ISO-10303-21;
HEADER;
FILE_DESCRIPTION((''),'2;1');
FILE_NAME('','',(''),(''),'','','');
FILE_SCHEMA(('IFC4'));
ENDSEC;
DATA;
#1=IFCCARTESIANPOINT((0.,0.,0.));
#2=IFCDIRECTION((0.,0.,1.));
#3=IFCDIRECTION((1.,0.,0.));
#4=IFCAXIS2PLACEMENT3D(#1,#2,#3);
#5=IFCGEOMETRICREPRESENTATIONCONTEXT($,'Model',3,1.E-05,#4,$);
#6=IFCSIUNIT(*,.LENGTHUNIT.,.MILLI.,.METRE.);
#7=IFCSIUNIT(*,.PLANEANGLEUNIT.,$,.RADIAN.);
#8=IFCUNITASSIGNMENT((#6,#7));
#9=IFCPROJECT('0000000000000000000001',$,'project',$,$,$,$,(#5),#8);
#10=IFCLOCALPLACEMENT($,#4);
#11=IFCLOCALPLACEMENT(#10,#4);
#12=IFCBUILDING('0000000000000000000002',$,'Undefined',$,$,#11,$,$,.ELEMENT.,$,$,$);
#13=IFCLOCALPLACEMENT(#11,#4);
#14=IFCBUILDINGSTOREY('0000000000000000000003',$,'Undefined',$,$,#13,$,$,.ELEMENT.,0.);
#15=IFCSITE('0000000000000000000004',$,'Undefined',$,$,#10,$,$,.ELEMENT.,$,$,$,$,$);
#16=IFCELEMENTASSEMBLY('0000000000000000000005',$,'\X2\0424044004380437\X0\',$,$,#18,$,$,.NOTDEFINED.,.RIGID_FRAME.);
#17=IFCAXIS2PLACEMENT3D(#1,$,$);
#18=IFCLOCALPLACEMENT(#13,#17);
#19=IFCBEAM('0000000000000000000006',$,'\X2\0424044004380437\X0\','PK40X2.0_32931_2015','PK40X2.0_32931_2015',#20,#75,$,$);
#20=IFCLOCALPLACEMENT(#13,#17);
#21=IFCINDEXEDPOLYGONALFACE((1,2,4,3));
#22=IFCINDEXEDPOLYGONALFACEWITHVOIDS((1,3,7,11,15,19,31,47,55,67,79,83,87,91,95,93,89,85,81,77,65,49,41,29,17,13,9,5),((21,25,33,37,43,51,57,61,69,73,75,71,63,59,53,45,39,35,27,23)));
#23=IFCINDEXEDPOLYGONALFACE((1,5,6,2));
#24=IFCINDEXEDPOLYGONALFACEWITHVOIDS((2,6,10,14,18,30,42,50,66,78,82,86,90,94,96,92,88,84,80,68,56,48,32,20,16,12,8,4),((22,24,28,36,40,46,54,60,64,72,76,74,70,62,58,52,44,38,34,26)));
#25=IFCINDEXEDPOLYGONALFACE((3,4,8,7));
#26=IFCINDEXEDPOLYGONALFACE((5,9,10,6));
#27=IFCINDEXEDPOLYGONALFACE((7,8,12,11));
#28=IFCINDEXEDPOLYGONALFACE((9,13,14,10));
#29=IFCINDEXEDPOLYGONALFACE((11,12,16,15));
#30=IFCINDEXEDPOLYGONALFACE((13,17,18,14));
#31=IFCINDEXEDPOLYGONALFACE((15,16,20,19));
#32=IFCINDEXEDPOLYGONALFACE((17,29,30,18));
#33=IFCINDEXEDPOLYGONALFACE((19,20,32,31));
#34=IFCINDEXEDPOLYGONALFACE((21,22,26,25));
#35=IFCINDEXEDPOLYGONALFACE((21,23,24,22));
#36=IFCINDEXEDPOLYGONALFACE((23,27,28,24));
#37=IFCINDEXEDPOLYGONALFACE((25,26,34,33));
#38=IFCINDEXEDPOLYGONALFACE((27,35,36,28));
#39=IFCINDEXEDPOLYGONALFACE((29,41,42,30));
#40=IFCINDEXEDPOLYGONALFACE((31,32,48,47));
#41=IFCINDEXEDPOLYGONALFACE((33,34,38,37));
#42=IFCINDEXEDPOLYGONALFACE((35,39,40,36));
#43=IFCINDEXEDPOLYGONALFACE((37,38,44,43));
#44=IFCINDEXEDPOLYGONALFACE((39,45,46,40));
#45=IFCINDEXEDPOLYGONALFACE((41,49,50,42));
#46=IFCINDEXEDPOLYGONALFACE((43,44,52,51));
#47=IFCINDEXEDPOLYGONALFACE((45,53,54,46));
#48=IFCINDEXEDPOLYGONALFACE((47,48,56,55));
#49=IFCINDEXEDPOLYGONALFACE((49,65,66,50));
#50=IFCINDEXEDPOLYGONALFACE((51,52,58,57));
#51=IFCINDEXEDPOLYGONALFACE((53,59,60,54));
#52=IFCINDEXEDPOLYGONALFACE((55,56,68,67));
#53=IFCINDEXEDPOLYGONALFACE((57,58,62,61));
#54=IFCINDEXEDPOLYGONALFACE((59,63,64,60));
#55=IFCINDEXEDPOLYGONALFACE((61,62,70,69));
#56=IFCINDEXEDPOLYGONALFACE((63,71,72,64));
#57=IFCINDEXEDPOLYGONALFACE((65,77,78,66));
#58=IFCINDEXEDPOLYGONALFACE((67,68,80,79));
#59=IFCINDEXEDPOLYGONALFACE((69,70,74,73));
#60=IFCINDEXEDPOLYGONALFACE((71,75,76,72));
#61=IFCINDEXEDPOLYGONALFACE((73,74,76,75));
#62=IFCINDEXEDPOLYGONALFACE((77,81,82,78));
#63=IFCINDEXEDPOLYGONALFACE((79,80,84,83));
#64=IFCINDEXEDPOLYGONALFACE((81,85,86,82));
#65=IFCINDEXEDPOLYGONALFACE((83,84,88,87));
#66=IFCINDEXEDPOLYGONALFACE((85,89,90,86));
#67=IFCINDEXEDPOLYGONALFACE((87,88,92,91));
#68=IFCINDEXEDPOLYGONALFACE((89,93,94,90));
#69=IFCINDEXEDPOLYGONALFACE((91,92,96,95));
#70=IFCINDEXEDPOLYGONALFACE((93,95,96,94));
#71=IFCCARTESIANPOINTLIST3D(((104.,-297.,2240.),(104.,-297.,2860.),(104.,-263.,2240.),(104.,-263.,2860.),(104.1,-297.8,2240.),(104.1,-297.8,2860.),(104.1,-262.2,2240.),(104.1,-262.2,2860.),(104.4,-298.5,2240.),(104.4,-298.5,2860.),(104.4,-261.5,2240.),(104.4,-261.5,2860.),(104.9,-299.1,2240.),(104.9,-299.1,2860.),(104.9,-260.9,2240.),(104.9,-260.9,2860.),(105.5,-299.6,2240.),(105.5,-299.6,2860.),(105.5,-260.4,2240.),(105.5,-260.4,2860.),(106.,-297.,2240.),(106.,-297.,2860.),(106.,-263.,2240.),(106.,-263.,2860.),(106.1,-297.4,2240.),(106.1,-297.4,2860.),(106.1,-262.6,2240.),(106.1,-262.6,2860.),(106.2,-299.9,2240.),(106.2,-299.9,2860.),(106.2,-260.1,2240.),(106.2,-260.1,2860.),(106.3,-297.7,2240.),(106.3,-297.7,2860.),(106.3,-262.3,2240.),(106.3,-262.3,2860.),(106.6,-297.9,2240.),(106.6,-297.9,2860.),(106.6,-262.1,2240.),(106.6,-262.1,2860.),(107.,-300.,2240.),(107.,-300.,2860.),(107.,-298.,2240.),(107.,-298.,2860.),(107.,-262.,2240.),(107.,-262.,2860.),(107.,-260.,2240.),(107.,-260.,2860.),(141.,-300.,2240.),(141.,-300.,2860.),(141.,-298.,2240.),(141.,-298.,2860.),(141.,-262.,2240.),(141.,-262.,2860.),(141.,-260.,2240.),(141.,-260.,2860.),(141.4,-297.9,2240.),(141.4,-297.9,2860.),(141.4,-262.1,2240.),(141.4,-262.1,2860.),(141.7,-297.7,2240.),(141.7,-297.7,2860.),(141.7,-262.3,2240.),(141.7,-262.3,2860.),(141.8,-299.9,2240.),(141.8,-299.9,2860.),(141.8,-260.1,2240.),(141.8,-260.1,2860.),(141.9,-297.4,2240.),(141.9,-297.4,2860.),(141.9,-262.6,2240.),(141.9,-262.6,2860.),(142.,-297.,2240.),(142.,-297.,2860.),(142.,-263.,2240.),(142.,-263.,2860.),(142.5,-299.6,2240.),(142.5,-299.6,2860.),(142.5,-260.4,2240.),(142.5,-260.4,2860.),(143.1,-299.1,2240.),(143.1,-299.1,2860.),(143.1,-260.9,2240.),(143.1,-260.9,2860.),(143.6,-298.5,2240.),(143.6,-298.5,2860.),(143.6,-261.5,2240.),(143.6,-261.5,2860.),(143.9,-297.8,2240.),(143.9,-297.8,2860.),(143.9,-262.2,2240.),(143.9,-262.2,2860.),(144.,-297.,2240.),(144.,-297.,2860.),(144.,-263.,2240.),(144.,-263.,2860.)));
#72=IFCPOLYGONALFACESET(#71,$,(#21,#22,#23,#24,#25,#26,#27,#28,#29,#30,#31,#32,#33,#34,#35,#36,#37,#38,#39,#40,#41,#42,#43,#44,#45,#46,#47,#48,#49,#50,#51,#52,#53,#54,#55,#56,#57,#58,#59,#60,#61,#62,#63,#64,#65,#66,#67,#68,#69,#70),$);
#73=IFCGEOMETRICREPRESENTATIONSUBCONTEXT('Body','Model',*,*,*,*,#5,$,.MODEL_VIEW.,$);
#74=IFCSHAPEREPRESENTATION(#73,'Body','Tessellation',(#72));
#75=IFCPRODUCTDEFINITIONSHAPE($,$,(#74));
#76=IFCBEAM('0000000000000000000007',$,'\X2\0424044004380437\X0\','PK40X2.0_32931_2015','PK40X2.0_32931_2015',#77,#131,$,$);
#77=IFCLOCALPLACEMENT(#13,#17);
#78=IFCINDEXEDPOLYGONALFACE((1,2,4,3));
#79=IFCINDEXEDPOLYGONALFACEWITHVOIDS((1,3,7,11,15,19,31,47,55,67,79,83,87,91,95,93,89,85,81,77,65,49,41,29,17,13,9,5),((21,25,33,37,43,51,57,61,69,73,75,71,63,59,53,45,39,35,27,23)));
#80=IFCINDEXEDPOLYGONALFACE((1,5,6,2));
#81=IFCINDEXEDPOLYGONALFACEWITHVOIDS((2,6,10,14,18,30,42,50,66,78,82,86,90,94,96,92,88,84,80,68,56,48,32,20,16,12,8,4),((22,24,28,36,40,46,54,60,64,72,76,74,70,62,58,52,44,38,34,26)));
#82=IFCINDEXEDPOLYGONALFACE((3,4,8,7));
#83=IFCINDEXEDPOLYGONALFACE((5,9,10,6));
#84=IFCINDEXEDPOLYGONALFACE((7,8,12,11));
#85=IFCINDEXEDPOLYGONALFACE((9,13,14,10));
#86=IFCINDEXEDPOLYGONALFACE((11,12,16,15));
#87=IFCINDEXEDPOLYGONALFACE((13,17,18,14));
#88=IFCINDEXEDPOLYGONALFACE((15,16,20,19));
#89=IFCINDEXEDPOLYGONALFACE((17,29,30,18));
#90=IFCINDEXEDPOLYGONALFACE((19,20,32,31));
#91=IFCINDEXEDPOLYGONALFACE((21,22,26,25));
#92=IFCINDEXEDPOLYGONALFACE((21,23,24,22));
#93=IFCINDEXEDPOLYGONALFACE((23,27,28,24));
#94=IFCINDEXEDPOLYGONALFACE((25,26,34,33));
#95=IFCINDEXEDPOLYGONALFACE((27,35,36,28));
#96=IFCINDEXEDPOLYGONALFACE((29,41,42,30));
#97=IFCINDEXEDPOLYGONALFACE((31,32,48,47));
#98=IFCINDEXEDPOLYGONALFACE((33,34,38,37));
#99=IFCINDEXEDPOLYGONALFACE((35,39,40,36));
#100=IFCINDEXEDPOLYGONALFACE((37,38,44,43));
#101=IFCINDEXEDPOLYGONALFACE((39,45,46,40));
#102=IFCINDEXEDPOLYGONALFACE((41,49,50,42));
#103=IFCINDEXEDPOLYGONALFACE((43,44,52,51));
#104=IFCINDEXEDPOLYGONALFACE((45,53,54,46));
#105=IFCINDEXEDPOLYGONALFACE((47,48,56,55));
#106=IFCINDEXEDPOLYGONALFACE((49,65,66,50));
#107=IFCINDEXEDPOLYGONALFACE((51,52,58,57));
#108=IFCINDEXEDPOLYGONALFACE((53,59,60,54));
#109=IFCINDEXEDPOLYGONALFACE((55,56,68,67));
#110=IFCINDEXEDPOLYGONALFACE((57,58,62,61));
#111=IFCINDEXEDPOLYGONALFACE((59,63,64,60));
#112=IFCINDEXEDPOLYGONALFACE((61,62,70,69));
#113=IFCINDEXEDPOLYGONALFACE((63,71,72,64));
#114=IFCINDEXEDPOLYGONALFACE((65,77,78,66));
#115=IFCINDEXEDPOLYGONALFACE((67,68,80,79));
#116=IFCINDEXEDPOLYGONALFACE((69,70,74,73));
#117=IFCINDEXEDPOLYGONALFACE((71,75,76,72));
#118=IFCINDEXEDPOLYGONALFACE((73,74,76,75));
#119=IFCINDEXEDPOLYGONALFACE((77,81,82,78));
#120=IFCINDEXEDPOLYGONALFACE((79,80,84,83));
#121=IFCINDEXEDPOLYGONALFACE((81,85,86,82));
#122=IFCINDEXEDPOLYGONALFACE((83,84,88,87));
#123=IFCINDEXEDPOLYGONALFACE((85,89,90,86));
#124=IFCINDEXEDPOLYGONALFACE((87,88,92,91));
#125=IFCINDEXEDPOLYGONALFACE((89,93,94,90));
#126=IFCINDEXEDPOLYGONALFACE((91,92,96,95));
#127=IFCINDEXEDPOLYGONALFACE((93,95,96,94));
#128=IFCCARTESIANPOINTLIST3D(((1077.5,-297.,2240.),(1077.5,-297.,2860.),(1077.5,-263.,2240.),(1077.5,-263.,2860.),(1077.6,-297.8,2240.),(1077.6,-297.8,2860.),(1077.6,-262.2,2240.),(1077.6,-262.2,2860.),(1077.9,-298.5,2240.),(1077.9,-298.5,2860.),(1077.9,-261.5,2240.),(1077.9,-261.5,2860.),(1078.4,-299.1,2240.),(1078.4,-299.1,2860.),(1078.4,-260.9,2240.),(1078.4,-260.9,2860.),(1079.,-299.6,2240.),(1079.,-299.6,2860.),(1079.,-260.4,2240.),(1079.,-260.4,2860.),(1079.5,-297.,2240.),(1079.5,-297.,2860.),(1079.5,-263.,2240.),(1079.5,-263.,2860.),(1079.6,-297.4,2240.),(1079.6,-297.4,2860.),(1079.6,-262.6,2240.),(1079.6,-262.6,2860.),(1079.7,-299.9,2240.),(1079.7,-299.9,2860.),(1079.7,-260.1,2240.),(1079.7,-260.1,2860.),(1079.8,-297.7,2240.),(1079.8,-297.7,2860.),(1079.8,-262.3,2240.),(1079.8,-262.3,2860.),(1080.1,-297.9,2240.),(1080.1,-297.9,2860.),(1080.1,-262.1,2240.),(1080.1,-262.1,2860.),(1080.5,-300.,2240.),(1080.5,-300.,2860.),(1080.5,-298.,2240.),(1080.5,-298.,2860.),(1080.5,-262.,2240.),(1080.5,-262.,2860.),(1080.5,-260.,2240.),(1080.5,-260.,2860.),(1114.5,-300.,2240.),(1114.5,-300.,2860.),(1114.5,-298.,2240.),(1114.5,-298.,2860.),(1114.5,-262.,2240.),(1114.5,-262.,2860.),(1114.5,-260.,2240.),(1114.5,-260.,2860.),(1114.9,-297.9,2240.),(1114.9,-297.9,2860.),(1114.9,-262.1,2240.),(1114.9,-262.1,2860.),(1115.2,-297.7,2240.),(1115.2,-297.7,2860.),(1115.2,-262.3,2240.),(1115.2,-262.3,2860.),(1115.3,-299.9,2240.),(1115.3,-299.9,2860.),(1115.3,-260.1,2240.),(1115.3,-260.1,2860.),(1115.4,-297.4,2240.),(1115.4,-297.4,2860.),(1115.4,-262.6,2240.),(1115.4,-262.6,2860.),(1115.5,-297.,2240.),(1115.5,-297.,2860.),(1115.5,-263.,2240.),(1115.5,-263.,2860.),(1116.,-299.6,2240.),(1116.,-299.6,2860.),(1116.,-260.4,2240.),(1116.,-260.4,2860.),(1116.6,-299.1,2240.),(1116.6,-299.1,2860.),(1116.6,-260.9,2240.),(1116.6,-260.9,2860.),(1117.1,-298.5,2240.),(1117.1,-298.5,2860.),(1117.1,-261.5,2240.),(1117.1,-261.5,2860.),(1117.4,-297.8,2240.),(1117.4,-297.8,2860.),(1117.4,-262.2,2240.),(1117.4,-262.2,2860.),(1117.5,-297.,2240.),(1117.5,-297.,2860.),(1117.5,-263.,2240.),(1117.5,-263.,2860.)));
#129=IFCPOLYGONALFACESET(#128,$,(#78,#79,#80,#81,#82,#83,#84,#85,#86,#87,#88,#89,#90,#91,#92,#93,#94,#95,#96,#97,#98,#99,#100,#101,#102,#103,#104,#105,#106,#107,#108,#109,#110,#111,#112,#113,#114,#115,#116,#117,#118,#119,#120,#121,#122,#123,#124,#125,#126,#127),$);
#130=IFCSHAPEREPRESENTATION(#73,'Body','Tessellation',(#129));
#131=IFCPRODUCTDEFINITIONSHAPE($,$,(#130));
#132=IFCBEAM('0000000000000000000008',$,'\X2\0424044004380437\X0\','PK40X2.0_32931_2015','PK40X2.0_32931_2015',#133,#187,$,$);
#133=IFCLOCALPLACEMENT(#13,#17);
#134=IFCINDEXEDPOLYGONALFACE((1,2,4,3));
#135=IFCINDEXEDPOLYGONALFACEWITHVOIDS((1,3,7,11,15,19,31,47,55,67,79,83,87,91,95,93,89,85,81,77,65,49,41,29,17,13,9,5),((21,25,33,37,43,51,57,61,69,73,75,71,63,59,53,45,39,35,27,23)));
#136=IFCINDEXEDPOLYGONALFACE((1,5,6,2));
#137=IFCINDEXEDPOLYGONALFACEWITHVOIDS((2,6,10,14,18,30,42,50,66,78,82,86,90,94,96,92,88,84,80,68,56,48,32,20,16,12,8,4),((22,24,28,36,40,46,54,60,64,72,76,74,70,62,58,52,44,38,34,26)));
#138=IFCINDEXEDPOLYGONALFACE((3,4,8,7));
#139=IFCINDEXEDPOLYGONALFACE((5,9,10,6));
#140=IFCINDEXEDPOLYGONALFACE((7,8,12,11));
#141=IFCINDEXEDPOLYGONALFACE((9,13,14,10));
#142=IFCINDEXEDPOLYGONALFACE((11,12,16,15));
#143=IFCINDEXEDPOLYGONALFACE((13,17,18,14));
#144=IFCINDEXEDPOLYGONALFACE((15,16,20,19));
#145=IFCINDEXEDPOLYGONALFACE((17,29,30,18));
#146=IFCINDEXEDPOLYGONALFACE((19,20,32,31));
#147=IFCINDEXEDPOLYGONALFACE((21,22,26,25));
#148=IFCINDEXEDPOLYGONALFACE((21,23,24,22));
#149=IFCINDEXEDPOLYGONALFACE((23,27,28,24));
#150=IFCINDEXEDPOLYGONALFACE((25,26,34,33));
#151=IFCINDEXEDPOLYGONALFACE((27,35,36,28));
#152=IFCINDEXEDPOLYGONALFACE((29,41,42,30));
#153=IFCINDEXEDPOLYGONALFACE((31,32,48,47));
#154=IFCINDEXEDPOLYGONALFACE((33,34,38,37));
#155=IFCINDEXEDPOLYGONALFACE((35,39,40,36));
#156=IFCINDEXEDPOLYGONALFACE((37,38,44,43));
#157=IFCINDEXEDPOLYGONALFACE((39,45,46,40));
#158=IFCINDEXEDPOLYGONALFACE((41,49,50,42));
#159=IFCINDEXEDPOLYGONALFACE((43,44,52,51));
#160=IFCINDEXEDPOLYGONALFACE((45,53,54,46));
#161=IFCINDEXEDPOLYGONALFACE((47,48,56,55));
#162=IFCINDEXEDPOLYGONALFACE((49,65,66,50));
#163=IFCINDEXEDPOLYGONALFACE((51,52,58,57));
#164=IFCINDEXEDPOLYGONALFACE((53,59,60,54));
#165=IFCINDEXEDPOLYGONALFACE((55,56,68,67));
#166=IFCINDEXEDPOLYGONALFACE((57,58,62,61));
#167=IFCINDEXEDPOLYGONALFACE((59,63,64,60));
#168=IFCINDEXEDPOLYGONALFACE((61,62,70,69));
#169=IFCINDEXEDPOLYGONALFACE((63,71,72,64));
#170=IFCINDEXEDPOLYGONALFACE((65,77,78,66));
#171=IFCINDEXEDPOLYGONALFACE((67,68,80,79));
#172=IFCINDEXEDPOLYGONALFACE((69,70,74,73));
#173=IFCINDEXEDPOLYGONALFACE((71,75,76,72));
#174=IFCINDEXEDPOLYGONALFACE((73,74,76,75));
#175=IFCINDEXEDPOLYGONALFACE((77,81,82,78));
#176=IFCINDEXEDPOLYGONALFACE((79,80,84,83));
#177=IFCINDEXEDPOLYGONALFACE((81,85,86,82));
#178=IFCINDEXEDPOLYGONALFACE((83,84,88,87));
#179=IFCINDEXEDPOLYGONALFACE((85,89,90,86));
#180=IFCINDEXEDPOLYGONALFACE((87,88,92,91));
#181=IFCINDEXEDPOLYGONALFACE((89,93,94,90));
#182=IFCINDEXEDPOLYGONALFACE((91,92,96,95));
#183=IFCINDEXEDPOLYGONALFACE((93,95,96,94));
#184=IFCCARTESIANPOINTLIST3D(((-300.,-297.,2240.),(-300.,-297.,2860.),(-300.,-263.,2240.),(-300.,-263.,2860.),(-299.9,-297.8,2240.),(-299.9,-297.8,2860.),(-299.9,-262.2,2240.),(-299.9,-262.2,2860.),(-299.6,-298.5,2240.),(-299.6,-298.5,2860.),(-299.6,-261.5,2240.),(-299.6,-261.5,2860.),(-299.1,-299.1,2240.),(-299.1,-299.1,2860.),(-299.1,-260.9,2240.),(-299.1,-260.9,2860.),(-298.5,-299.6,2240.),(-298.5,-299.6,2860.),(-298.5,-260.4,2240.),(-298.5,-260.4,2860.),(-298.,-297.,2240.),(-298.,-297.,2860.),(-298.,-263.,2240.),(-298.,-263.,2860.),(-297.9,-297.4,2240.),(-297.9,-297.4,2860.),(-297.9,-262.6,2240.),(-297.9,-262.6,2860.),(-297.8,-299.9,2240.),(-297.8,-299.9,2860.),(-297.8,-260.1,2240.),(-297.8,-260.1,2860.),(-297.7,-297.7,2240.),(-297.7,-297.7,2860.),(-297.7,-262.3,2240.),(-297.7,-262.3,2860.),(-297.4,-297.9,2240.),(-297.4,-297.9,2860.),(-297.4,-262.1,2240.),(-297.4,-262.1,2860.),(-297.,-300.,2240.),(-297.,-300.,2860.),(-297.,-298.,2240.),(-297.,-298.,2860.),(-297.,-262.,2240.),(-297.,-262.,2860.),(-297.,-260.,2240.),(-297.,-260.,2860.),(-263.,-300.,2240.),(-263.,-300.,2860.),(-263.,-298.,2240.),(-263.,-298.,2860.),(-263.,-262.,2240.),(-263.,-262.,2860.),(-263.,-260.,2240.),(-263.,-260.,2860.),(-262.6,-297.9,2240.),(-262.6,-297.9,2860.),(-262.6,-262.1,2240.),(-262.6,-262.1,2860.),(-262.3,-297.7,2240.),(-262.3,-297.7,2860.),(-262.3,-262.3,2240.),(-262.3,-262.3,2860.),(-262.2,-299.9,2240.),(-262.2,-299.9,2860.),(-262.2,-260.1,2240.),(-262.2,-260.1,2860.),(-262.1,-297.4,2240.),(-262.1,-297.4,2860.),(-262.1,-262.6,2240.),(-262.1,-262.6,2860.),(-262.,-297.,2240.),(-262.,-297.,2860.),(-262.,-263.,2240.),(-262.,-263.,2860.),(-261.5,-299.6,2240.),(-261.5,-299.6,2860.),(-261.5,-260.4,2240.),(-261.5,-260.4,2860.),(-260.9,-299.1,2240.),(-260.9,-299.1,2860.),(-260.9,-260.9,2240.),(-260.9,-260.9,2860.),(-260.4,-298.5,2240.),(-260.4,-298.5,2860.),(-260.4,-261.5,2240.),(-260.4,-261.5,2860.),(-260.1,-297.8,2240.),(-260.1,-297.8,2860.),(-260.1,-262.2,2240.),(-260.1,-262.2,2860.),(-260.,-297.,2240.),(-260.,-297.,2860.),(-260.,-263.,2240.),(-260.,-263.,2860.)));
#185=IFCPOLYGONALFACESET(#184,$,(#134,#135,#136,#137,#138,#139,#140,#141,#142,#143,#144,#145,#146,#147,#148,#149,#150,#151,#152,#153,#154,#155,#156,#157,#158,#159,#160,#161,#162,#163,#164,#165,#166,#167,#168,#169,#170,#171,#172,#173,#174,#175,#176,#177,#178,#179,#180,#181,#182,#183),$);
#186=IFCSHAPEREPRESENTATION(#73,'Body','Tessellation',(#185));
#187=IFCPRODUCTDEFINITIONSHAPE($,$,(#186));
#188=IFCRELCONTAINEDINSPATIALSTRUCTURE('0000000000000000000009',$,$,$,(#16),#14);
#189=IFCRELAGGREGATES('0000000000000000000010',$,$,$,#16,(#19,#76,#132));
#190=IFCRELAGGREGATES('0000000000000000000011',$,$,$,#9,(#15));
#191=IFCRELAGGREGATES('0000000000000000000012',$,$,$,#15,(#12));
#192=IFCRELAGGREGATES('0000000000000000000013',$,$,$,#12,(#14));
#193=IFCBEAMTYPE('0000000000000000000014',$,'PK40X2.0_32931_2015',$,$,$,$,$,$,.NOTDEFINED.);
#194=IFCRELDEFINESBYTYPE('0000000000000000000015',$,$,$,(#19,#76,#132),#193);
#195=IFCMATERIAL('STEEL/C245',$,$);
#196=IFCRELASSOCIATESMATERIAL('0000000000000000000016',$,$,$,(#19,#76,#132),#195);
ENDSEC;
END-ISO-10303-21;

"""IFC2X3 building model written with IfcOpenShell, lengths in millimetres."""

from ifc_helpers import new_model, si_unit, frame, origin_with_axes, origin_2d_with_axis, place, context, subcontext, project, spatial, hollow_rectangle, extrude, material, type_object, element, aggregate, save


model = new_model("IFC2X3")

# Units and contexts
model_context = context("Model", 3, precision=1e-05, world=origin_with_axes())
body_context = subcontext(model_context, "Body", "Model", "MODEL_VIEW")
ifc_project = project(units=[si_unit("LENGTHUNIT", "METRE", prefix="MILLI"), si_unit("PLANEANGLEUNIT", "RADIAN")], contexts=[model_context])

# Site, building, storey
site_placement = place(None, origin_with_axes())
site = spatial("IfcSite", under=ifc_project, at=site_placement, Name="Undefined", CompositionType="ELEMENT")
building_placement = place(site_placement, origin_with_axes())
building = spatial("IfcBuilding", under=site, at=building_placement, Name="Undefined", CompositionType="ELEMENT")
storey_placement = place(building_placement, origin_with_axes())
storey = spatial("IfcBuildingStorey", under=building, at=storey_placement, Name="Undefined", CompositionType="ELEMENT", Elevation=0.0)

# Shared definitions
ifc_material_1 = material(Name="STEEL/C245")

# Shared definitions
beam_type_1 = type_object("IfcBeamType", Name="PK40X2.0_32931_2015", PredefinedType="NOTDEFINED")

# Element assembly, beams
assembly_1_placement = place(storey_placement, origin_with_axes())
assembly_1 = element("IfcElementAssembly", 1, at=assembly_1_placement, inside=storey, Name="Фриз", AssemblyPlace="NOTDEFINED", PredefinedType="RIGID_FRAME")
beam_1_placement = place(assembly_1_placement, frame((124.0, -280.0, 2860.0), z_axis=(1.0, 0.0, 0.0), x_axis=(0.0, 0.0, -1.0)))
beam_1 = element("IfcBeam", 2, at=beam_1_placement, type_object=beam_type_1, material=ifc_material_1, Name="Фриз", Description="PK40X2.0_32931_2015", ObjectType="PK40X2.0_32931_2015", context=body_context, shape_type="SweptSolid", body=[
    extrude(hollow_rectangle(XDim=40.0, YDim=40.0, WallThickness=2.0, InnerFilletRadius=1.0, OuterFilletRadius=3.0, at=origin_2d_with_axis()), frame((620.0, 0.0, 0.0), z_axis=(-1.0, 0.0, 0.0), x_axis=(0.0, -1.0, 0.0)), (0.0, 0.0, 1.0), 620.0),
])
beam_2_placement = place(assembly_1_placement, frame((1097.5, -280.0, 2860.0), z_axis=(1.0, 0.0, 0.0), x_axis=(0.0, 0.0, -1.0)))
beam_2 = element("IfcBeam", 3, at=beam_2_placement, type_object=beam_type_1, material=ifc_material_1, Name="Фриз", Description="PK40X2.0_32931_2015", ObjectType="PK40X2.0_32931_2015", context=body_context, shape_type="SweptSolid", body=[
    extrude(hollow_rectangle(XDim=40.0, YDim=40.0, WallThickness=2.0, InnerFilletRadius=1.0, OuterFilletRadius=3.0, at=origin_2d_with_axis()), frame((620.0, 0.0, 0.0), z_axis=(-1.0, 0.0, 0.0), x_axis=(0.0, -1.0, 0.0)), (0.0, 0.0, 1.0), 620.0),
])
beam_3_placement = place(assembly_1_placement, frame((-280.0, -280.0, 2860.0), z_axis=(-1.0, 0.0, 0.0), x_axis=(0.0, 0.0, -1.0)))
beam_3 = element("IfcBeam", 4, at=beam_3_placement, type_object=beam_type_1, material=ifc_material_1, Name="Фриз", Description="PK40X2.0_32931_2015", ObjectType="PK40X2.0_32931_2015", context=body_context, shape_type="SweptSolid", body=[
    extrude(hollow_rectangle(XDim=40.0, YDim=40.0, WallThickness=2.0, InnerFilletRadius=1.0, OuterFilletRadius=3.0, at=origin_2d_with_axis()), frame((620.0, 0.0, 0.0), z_axis=(-1.0, 0.0, 0.0), x_axis=(0.0, -1.0, 0.0)), (0.0, 0.0, 1.0), 620.0),
])
aggregate(assembly_1, [beam_1, beam_2, beam_3])

save(model, "model.ifc")
